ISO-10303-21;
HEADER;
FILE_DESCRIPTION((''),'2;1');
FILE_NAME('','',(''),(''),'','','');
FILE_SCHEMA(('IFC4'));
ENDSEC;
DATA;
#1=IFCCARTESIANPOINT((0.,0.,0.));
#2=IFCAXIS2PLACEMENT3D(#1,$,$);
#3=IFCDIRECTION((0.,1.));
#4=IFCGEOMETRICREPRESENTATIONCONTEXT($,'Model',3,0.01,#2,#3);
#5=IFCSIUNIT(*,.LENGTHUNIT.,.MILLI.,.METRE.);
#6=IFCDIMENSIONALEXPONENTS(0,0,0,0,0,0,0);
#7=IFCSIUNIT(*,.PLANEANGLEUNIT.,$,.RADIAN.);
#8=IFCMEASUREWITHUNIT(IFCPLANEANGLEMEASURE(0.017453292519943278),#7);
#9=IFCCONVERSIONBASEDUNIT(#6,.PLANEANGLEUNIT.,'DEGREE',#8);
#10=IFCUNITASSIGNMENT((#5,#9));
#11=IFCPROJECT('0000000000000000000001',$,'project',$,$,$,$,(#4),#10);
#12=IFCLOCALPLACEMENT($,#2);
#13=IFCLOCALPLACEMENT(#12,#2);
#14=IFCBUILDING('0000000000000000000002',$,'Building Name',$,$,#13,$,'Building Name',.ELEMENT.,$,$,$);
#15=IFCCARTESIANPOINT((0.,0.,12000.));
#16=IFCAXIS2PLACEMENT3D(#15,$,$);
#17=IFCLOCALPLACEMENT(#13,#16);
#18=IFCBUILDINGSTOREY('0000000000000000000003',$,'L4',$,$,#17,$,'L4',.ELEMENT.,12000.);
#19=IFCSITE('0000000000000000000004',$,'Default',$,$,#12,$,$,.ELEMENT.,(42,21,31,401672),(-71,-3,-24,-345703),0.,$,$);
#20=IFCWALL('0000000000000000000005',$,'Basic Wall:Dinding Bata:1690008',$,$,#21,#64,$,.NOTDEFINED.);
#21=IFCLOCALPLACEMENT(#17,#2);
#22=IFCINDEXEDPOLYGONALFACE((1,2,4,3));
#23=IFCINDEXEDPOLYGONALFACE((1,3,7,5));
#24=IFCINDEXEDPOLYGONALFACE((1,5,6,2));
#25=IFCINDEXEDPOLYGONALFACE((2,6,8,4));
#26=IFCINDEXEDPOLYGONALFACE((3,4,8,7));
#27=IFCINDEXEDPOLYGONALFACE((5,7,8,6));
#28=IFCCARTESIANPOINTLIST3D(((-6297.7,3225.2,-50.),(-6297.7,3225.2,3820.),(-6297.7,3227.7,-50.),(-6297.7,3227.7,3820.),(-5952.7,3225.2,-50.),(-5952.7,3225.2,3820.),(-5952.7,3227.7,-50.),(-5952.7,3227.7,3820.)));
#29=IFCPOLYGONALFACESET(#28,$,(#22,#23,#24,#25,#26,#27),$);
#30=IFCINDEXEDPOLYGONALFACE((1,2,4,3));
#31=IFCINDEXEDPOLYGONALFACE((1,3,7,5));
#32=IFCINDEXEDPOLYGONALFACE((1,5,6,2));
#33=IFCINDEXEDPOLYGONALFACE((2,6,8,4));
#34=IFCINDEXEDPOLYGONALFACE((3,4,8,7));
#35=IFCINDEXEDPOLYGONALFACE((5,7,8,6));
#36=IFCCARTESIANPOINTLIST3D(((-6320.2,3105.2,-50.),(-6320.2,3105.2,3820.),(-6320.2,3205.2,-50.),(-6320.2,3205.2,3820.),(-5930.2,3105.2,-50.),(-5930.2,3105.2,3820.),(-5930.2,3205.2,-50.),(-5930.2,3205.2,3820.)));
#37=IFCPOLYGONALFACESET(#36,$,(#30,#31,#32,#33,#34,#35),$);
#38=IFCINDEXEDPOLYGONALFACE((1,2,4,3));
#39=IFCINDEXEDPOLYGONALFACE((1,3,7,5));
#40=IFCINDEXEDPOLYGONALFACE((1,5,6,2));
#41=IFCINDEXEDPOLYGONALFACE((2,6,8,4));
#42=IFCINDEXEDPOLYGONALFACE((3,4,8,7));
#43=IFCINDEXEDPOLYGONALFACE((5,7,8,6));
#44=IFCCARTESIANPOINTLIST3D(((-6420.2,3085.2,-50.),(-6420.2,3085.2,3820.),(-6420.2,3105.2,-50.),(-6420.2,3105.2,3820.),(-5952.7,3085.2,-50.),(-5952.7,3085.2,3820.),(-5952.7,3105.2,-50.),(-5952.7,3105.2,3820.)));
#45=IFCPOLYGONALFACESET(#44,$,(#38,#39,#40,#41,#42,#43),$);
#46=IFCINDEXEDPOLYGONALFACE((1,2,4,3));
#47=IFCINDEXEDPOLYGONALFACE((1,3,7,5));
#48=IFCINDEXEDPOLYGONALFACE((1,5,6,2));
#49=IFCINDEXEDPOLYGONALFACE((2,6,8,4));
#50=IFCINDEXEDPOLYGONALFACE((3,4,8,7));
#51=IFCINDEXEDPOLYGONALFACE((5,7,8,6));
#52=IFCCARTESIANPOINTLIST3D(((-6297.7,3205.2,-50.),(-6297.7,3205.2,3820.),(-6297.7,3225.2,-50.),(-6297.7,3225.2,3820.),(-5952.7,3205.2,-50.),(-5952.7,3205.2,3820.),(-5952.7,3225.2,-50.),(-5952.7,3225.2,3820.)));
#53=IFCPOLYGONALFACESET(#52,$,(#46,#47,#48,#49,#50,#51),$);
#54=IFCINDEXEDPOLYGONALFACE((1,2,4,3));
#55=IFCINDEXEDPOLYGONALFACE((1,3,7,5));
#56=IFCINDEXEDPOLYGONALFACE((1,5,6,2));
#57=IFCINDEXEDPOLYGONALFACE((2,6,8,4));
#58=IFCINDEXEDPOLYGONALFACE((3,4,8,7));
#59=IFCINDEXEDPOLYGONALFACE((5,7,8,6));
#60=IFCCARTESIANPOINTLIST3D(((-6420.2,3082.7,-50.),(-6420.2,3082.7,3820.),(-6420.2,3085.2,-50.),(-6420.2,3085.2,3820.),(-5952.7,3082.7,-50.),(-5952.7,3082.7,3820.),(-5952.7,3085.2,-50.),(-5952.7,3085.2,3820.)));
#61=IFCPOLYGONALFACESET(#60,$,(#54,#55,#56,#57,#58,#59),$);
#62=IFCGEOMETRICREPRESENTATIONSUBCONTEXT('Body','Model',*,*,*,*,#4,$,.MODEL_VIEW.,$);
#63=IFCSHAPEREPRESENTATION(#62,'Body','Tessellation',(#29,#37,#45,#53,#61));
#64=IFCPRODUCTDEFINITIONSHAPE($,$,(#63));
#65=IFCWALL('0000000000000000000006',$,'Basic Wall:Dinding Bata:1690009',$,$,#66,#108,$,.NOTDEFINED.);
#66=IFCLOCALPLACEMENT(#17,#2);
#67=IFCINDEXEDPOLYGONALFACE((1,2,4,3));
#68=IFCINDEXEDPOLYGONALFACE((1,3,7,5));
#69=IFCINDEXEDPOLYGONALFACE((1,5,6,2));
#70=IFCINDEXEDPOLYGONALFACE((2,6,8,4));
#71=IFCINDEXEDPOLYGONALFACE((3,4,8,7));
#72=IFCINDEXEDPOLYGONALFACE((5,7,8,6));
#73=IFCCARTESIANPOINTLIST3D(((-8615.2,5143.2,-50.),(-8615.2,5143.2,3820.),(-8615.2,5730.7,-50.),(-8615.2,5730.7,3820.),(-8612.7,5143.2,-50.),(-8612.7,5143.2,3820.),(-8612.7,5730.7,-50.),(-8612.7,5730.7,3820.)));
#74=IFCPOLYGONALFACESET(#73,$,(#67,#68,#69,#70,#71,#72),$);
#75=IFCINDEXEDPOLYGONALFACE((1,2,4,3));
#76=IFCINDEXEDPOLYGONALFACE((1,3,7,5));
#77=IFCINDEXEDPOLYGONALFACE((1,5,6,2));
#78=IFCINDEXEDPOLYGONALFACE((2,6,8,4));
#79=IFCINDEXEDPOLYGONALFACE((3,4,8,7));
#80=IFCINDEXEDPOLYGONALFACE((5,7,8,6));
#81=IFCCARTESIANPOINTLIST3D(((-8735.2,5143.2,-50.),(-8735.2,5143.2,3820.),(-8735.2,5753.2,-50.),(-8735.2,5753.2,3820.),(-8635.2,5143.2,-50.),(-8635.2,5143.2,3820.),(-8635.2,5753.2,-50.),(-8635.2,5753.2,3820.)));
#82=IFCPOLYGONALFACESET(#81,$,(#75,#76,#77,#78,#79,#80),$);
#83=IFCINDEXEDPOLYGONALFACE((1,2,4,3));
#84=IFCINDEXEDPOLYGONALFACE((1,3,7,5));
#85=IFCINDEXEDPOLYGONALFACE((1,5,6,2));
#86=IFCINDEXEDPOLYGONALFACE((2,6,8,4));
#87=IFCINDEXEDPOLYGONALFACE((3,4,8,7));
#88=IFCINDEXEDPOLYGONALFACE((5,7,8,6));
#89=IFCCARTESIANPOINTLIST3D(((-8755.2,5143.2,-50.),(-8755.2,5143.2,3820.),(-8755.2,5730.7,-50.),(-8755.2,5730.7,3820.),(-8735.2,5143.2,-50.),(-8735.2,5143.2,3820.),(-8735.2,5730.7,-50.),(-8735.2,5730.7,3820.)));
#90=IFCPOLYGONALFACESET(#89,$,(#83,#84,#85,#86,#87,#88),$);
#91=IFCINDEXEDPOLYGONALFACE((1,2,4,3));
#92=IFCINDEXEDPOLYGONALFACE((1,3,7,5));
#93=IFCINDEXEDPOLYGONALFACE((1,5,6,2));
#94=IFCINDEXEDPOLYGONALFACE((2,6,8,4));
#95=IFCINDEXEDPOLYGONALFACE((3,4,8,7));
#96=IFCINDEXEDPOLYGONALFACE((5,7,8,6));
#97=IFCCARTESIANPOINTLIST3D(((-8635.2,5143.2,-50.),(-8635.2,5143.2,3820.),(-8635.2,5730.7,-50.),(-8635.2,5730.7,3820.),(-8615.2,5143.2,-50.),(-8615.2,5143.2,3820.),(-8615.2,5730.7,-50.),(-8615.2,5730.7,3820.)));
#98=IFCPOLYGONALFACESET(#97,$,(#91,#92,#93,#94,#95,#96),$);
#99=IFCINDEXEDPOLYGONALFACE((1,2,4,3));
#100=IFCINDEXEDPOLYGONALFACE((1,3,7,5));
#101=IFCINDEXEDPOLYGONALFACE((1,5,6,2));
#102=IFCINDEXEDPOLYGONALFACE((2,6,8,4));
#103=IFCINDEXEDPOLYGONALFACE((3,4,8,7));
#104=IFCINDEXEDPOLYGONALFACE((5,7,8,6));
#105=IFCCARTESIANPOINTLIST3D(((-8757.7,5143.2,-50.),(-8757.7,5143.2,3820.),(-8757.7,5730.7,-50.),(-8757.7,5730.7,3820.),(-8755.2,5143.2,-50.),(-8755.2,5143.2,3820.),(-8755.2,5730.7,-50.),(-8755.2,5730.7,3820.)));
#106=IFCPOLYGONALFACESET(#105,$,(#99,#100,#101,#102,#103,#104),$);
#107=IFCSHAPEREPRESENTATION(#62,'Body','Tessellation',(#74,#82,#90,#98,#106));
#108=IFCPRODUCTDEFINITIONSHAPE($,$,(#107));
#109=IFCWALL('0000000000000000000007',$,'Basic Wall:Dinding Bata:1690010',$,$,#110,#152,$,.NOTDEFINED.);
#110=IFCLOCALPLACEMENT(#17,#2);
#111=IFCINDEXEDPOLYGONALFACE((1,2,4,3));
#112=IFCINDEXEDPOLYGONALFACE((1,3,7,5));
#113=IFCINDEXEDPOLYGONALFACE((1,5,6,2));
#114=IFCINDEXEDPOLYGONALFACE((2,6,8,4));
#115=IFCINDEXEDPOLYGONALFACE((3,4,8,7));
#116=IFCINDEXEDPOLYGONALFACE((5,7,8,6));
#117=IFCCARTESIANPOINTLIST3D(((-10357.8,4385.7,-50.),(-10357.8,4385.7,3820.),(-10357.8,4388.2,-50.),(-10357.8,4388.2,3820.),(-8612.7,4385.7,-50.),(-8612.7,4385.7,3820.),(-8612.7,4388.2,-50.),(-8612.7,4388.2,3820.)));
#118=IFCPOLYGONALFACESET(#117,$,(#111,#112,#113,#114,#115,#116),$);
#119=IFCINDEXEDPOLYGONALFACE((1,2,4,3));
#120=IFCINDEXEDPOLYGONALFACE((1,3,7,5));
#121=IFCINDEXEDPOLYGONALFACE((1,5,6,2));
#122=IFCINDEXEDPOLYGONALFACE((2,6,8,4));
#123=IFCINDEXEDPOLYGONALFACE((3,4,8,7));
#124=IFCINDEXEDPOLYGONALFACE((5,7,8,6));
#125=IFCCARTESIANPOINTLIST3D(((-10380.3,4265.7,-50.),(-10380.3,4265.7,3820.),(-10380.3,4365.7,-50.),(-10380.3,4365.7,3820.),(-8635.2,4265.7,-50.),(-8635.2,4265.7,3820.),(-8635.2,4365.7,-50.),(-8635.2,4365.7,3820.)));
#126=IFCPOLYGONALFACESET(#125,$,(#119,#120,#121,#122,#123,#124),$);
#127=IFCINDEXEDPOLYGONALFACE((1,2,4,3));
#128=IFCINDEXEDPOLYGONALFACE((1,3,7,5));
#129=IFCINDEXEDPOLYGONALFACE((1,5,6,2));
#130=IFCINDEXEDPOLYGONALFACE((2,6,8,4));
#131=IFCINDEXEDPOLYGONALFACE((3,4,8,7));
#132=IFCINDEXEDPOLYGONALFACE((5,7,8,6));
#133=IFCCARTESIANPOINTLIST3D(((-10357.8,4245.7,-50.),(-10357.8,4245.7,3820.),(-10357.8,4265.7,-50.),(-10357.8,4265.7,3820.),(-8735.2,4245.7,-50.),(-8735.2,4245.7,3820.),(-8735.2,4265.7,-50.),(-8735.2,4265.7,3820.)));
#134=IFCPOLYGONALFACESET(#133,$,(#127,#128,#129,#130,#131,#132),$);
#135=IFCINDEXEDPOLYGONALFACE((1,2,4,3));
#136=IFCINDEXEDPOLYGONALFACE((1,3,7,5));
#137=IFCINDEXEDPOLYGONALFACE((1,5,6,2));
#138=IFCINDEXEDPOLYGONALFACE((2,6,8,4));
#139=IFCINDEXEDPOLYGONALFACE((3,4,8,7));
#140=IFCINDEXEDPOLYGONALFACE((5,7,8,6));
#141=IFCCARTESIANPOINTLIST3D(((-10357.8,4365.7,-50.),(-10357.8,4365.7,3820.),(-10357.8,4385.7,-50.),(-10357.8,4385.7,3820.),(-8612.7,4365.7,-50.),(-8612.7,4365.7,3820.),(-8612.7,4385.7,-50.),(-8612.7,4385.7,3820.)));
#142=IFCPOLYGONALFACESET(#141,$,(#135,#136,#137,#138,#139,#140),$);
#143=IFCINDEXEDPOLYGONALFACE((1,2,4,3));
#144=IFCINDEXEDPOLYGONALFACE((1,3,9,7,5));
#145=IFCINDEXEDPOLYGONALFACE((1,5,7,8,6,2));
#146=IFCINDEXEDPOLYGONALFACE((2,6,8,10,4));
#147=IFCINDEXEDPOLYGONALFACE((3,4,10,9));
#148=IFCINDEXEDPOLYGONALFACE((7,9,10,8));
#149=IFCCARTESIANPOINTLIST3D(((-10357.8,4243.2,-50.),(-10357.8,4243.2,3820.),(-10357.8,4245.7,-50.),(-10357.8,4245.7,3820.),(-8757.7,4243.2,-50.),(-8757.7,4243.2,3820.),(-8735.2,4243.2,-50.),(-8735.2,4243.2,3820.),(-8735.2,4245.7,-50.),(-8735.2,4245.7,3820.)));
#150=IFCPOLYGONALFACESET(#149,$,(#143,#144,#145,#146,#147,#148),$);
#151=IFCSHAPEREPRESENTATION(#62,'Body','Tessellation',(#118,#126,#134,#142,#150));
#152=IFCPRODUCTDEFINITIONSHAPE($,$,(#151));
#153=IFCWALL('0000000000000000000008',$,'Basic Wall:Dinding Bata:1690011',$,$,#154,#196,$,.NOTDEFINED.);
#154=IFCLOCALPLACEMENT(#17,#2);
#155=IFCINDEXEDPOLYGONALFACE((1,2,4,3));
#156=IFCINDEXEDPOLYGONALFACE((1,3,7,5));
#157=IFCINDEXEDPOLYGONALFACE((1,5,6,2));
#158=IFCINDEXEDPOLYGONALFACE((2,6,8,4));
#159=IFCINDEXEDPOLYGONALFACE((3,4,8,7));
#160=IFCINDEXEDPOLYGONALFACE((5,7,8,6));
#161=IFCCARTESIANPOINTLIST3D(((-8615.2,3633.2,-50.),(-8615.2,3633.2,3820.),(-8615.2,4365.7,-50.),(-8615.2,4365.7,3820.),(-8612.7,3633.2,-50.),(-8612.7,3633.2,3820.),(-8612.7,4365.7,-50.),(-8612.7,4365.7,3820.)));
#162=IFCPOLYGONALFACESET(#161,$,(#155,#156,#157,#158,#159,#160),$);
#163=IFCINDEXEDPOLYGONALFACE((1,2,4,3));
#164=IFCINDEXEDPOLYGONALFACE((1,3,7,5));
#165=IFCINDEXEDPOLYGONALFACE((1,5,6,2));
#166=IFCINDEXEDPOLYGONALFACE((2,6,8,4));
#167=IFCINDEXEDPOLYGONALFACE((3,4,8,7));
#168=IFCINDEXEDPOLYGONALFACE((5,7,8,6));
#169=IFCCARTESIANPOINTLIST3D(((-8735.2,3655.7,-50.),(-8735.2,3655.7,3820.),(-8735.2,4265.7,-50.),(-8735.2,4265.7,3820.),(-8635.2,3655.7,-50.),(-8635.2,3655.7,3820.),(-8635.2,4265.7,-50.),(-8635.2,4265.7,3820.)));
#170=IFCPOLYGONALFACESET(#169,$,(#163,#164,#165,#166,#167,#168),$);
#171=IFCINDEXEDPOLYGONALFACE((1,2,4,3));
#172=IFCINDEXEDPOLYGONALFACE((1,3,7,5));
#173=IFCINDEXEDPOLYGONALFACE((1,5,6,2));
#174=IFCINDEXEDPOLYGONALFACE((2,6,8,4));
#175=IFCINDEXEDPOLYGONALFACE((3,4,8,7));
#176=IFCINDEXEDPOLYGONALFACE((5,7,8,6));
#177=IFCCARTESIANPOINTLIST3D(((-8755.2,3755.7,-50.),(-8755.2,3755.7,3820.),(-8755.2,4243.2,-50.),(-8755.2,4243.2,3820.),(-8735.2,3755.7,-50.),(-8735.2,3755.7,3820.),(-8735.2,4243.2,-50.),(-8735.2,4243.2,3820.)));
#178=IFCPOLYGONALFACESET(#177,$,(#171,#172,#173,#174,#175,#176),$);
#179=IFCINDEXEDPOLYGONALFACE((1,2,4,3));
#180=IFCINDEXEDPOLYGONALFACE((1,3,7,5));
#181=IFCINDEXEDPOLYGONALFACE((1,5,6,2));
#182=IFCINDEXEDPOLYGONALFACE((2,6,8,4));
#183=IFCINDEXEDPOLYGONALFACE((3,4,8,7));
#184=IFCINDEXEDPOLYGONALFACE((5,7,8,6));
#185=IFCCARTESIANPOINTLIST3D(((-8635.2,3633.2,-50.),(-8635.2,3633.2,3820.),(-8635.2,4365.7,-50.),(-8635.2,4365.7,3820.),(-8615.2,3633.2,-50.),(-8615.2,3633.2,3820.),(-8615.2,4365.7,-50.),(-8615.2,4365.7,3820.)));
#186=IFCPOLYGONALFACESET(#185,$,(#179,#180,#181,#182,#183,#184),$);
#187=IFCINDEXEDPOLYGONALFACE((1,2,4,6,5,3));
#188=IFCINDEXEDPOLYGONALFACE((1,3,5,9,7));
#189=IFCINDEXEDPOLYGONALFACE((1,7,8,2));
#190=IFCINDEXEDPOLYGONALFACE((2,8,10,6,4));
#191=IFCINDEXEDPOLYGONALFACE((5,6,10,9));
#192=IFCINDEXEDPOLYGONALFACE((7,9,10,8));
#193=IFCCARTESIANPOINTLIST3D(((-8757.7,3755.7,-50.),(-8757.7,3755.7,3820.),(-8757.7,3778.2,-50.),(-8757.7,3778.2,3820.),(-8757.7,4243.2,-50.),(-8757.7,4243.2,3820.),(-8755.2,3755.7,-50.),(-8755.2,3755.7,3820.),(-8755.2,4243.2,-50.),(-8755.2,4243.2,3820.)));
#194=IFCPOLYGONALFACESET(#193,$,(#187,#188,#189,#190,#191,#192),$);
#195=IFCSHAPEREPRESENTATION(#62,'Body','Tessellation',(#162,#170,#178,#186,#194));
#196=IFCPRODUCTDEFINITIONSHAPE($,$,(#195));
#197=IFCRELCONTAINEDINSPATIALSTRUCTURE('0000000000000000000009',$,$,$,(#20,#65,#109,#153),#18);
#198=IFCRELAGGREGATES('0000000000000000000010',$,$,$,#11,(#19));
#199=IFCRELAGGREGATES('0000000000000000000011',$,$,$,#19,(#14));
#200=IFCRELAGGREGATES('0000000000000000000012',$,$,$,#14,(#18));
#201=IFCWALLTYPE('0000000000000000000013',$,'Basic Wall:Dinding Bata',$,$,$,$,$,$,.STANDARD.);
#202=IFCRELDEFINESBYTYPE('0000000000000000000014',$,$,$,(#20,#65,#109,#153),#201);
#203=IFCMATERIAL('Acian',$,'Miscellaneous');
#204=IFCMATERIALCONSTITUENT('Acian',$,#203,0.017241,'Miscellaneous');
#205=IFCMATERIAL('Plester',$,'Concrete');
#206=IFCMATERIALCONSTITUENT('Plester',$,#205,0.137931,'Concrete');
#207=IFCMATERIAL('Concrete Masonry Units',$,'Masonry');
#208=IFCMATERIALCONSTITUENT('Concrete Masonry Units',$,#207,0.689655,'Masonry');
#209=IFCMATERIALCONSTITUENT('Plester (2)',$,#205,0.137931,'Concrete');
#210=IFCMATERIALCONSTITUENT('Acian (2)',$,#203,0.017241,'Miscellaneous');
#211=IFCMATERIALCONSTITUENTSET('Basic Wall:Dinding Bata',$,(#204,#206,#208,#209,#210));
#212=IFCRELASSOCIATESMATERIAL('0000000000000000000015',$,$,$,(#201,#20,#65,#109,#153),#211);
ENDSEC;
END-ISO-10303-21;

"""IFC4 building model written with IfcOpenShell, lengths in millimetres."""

from ifc_helpers import new_model, entity, si_unit, converted_unit, direction, frame, origin, place, context, subcontext, project, spatial, indexed_curve, outline, extrude, material, constituent, constituent_set, type_object, element, save


model = new_model("IFC4")

# Units and contexts
model_context = context("Model", 3, precision=0.01, world=origin(), true_north=direction((0.0, 1.0)))
body_context = subcontext(model_context, "Body", "Model", "MODEL_VIEW")
ifc_project = project(units=[si_unit("LENGTHUNIT", "METRE", prefix="MILLI"), converted_unit("PLANEANGLEUNIT", "DEGREE", entity("IfcPlaneAngleMeasure", 0.017453292519943278), si_unit("PLANEANGLEUNIT", "RADIAN"), dimensions=[0, 0, 0, 0, 0, 0, 0])], contexts=[model_context])

# Site, building, storey
site_placement = place(None, origin())
site = spatial("IfcSite", under=ifc_project, at=site_placement, Name="Default", CompositionType="ELEMENT", RefLatitude=(42, 21, 31, 401672), RefLongitude=(-71, -3, -24, -345703), RefElevation=0.0)
building_placement = place(site_placement, origin())
building = spatial("IfcBuilding", under=site, at=building_placement, Name="Building Name", LongName="Building Name", CompositionType="ELEMENT")
storey_placement = place(building_placement, frame((0.0, 0.0, 12000.0)))
storey = spatial("IfcBuildingStorey", under=building, at=storey_placement, Name="L4", LongName="L4", CompositionType="ELEMENT", Elevation=12000.0)

# Walls
ifc_material_1 = material(Name="Acian", Category="Miscellaneous")
ifc_constituent_1 = constituent(ifc_material_1, Name="Acian", Category="Miscellaneous", fraction=0.017241)
ifc_material_2 = material(Name="Plester", Category="Concrete")
ifc_constituent_2 = constituent(ifc_material_2, Name="Plester", Category="Concrete", fraction=0.137931)
ifc_material_3 = material(Name="Concrete Masonry Units", Category="Masonry")
ifc_constituent_3 = constituent(ifc_material_3, Name="Concrete Masonry Units", Category="Masonry", fraction=0.689655)
ifc_constituent_4 = constituent(ifc_material_2, Name="Plester (2)", Category="Concrete", fraction=0.137931)
ifc_constituent_5 = constituent(ifc_material_1, Name="Acian (2)", Category="Miscellaneous", fraction=0.017241)
ifc_constituent_set = constituent_set(constituents=[ifc_constituent_1, ifc_constituent_2, ifc_constituent_3, ifc_constituent_4, ifc_constituent_5], Name="Basic Wall:Dinding Bata")
wall_type = type_object("IfcWallType", Name="Basic Wall:Dinding Bata", PredefinedType="STANDARD", material=ifc_constituent_set)
wall_1_placement = place(storey_placement, frame((-6297.7, 3155.2, -50.0)))
element("IfcWall", 1, at=wall_1_placement, inside=storey, type_object=wall_type, material=ifc_constituent_set, Name="Basic Wall:Dinding Bata:1690008", PredefinedType="NOTDEFINED", context=body_context, shape_type="SweptSolid", body=[
    extrude(outline(indexed_curve([(-1.3, -172.5), (1.2, -172.5), (1.3, 172.5), (-1.2, 172.5), (-1.3, -172.5)], self_intersect=False)), frame((172.5, 71.3, 0.0), z_axis=(0.0, 0.0, 1.0), x_axis=(0.0, -1.0, 0.0)), (0.0, 0.0, 1.0), 3870.0),
    extrude(outline(indexed_curve([(-195.0, -50.0), (195.0, -50.0), (195.0, 50.0), (-195.0, 50.0), (-195.0, -50.0)], self_intersect=False)), frame((172.5, 0.0, 0.0)), (0.0, 0.0, 1.0), 3870.0),
    extrude(outline(indexed_curve([(-233.8, -10.0), (233.8, -10.0), (233.8, 10.0), (-233.8, 10.0), (-233.8, -10.0)], self_intersect=False)), frame((111.3, -60.0, 0.0)), (0.0, 0.0, 1.0), 3870.0),
    extrude(outline(indexed_curve([(-172.5, -10.0), (172.5, -10.0), (172.5, 10.0), (-172.5, 10.0), (-172.5, -10.0)], self_intersect=False)), frame((172.5, 60.0, 0.0)), (0.0, 0.0, 1.0), 3870.0),
    extrude(outline(indexed_curve([(-1.3, -233.8), (1.2, -233.8), (1.3, 233.8), (-1.2, 233.8), (-1.3, -233.8)], self_intersect=False)), frame((111.3, -71.3, 0.0), z_axis=(0.0, 0.0, 1.0), x_axis=(0.0, 1.0, 0.0)), (0.0, 0.0, 1.0), 3870.0),
])
wall_2_placement = place(storey_placement, frame((-8685.2, 5730.7, -50.0), z_axis=(0.0, 0.0, 1.0), x_axis=(0.0, -1.0, 0.0)))
element("IfcWall", 2, at=wall_2_placement, inside=storey, type_object=wall_type, material=ifc_constituent_set, Name="Basic Wall:Dinding Bata:1690009", PredefinedType="NOTDEFINED", context=body_context, shape_type="SweptSolid", body=[
    extrude(outline(indexed_curve([(-1.3, -293.8), (1.2, -293.8), (1.2, 293.7), (-1.2, 293.7), (-1.3, -293.8)], self_intersect=False)), frame((293.8, 71.2, 0.0), z_axis=(0.0, 0.0, 1.0), x_axis=(0.0, -1.0, 0.0)), (0.0, 0.0, 1.0), 3870.0),
    extrude(outline(indexed_curve([(-305.0, -50.0), (305.0, -50.0), (305.0, 50.0), (-305.0, 50.0), (-305.0, -50.0)], self_intersect=False)), frame((282.5, 0.0, 0.0)), (0.0, 0.0, 1.0), 3870.0),
    extrude(outline(indexed_curve([(-293.8, -10.0), (293.8, -10.0), (293.8, 10.0), (-293.8, 10.0), (-293.8, -10.0)], self_intersect=False)), frame((293.8, -60.0, 0.0)), (0.0, 0.0, 1.0), 3870.0),
    extrude(outline(indexed_curve([(-293.8, -10.0), (293.7, -10.0), (293.7, 10.0), (-293.8, 10.0), (-293.8, -10.0)], self_intersect=False)), frame((293.8, 60.0, 0.0)), (0.0, 0.0, 1.0), 3870.0),
    extrude(outline(indexed_curve([(-1.2, -293.8), (1.2, -293.8), (1.3, 293.8), (-1.2, 293.8), (-1.2, -293.8)], self_intersect=False)), frame((293.8, -71.3, 0.0), z_axis=(0.0, 0.0, 1.0), x_axis=(0.0, 1.0, 0.0)), (0.0, 0.0, 1.0), 3870.0),
])
wall_3_placement = place(storey_placement, frame((-10357.8, 4315.7, -50.0)))
element("IfcWall", 3, at=wall_3_placement, inside=storey, type_object=wall_type, material=ifc_constituent_set, Name="Basic Wall:Dinding Bata:1690010", PredefinedType="NOTDEFINED", context=body_context, shape_type="SweptSolid", body=[
    extrude(outline(indexed_curve([(-1.3, -872.5), (1.2, -872.5), (1.3, 872.5), (-1.2, 872.5), (-1.3, -872.5)], self_intersect=False)), frame((872.5, 71.3, 0.0), z_axis=(0.0, 0.0, 1.0), x_axis=(0.0, -1.0, 0.0)), (0.0, 0.0, 1.0), 3870.0),
    extrude(outline(indexed_curve([(-872.5, -50.0), (872.5, -50.0), (872.5, 50.0), (-872.5, 50.0), (-872.5, -50.0)], self_intersect=False)), frame((850.0, 0.0, 0.0)), (0.0, 0.0, 1.0), 3870.0),
    extrude(outline(indexed_curve([(-811.3, -10.0), (811.3, -10.0), (811.3, 10.0), (-811.3, 10.0), (-811.3, -10.0)], self_intersect=False)), frame((811.3, -60.0, 0.0)), (0.0, 0.0, 1.0), 3870.0),
    extrude(outline(indexed_curve([(-872.5, -10.0), (872.5, -10.0), (872.5, 10.0), (-872.5, 10.0), (-872.5, -10.0)], self_intersect=False)), frame((872.5, 60.0, 0.0)), (0.0, 0.0, 1.0), 3870.0),
    extrude(outline(indexed_curve([(631.0, -1.0), (653.5, -1.0), (653.5, 1.5), (-969.0, 1.5), (-969.0, -1.0), (631.0, -1.0)], self_intersect=False)), frame((969.0, -71.5, 0.0)), (0.0, 0.0, 1.0), 3870.0),
])
wall_4_placement = place(storey_placement, frame((-8685.2, 4243.2, -50.0), z_axis=(0.0, 0.0, 1.0), x_axis=(0.0, -1.0, 0.0)))
element("IfcWall", 4, at=wall_4_placement, inside=storey, type_object=wall_type, material=ifc_constituent_set, Name="Basic Wall:Dinding Bata:1690011", PredefinedType="NOTDEFINED", context=body_context, shape_type="SweptSolid", body=[
    extrude(outline(indexed_curve([(-1.3, -366.3), (1.2, -366.3), (1.2, 366.3), (-1.2, 366.3), (-1.3, -366.3)], self_intersect=False)), frame((243.8, 71.2, 0.0), z_axis=(0.0, 0.0, 1.0), x_axis=(0.0, -1.0, 0.0)), (0.0, 0.0, 1.0), 3870.0),
    extrude(outline(indexed_curve([(-305.0, -50.0), (305.0, -50.0), (305.0, 50.0), (-305.0, 50.0), (-305.0, -50.0)], self_intersect=False)), frame((282.5, 0.0, 0.0)), (0.0, 0.0, 1.0), 3870.0),
    extrude(outline(indexed_curve([(-243.8, -10.0), (243.8, -10.0), (243.8, 10.0), (-243.8, 10.0), (-243.8, -10.0)], self_intersect=False)), frame((243.8, -60.0, 0.0)), (0.0, 0.0, 1.0), 3870.0),
    extrude(outline(indexed_curve([(-366.3, -10.0), (366.3, -10.0), (366.3, 10.0), (-366.3, 10.0), (-366.3, -10.0)], self_intersect=False)), frame((243.8, 60.0, 0.0)), (0.0, 0.0, 1.0), 3870.0),
    extrude(outline(indexed_curve([(177.0, -1.0), (199.5, -1.0), (199.5, 1.5), (-288.0, 1.5), (-288.0, -1.0), (177.0, -1.0)], self_intersect=False)), frame((288.0, -71.5, 0.0)), (0.0, 0.0, 1.0), 3870.0),
])

save(model, "model.ifc")
